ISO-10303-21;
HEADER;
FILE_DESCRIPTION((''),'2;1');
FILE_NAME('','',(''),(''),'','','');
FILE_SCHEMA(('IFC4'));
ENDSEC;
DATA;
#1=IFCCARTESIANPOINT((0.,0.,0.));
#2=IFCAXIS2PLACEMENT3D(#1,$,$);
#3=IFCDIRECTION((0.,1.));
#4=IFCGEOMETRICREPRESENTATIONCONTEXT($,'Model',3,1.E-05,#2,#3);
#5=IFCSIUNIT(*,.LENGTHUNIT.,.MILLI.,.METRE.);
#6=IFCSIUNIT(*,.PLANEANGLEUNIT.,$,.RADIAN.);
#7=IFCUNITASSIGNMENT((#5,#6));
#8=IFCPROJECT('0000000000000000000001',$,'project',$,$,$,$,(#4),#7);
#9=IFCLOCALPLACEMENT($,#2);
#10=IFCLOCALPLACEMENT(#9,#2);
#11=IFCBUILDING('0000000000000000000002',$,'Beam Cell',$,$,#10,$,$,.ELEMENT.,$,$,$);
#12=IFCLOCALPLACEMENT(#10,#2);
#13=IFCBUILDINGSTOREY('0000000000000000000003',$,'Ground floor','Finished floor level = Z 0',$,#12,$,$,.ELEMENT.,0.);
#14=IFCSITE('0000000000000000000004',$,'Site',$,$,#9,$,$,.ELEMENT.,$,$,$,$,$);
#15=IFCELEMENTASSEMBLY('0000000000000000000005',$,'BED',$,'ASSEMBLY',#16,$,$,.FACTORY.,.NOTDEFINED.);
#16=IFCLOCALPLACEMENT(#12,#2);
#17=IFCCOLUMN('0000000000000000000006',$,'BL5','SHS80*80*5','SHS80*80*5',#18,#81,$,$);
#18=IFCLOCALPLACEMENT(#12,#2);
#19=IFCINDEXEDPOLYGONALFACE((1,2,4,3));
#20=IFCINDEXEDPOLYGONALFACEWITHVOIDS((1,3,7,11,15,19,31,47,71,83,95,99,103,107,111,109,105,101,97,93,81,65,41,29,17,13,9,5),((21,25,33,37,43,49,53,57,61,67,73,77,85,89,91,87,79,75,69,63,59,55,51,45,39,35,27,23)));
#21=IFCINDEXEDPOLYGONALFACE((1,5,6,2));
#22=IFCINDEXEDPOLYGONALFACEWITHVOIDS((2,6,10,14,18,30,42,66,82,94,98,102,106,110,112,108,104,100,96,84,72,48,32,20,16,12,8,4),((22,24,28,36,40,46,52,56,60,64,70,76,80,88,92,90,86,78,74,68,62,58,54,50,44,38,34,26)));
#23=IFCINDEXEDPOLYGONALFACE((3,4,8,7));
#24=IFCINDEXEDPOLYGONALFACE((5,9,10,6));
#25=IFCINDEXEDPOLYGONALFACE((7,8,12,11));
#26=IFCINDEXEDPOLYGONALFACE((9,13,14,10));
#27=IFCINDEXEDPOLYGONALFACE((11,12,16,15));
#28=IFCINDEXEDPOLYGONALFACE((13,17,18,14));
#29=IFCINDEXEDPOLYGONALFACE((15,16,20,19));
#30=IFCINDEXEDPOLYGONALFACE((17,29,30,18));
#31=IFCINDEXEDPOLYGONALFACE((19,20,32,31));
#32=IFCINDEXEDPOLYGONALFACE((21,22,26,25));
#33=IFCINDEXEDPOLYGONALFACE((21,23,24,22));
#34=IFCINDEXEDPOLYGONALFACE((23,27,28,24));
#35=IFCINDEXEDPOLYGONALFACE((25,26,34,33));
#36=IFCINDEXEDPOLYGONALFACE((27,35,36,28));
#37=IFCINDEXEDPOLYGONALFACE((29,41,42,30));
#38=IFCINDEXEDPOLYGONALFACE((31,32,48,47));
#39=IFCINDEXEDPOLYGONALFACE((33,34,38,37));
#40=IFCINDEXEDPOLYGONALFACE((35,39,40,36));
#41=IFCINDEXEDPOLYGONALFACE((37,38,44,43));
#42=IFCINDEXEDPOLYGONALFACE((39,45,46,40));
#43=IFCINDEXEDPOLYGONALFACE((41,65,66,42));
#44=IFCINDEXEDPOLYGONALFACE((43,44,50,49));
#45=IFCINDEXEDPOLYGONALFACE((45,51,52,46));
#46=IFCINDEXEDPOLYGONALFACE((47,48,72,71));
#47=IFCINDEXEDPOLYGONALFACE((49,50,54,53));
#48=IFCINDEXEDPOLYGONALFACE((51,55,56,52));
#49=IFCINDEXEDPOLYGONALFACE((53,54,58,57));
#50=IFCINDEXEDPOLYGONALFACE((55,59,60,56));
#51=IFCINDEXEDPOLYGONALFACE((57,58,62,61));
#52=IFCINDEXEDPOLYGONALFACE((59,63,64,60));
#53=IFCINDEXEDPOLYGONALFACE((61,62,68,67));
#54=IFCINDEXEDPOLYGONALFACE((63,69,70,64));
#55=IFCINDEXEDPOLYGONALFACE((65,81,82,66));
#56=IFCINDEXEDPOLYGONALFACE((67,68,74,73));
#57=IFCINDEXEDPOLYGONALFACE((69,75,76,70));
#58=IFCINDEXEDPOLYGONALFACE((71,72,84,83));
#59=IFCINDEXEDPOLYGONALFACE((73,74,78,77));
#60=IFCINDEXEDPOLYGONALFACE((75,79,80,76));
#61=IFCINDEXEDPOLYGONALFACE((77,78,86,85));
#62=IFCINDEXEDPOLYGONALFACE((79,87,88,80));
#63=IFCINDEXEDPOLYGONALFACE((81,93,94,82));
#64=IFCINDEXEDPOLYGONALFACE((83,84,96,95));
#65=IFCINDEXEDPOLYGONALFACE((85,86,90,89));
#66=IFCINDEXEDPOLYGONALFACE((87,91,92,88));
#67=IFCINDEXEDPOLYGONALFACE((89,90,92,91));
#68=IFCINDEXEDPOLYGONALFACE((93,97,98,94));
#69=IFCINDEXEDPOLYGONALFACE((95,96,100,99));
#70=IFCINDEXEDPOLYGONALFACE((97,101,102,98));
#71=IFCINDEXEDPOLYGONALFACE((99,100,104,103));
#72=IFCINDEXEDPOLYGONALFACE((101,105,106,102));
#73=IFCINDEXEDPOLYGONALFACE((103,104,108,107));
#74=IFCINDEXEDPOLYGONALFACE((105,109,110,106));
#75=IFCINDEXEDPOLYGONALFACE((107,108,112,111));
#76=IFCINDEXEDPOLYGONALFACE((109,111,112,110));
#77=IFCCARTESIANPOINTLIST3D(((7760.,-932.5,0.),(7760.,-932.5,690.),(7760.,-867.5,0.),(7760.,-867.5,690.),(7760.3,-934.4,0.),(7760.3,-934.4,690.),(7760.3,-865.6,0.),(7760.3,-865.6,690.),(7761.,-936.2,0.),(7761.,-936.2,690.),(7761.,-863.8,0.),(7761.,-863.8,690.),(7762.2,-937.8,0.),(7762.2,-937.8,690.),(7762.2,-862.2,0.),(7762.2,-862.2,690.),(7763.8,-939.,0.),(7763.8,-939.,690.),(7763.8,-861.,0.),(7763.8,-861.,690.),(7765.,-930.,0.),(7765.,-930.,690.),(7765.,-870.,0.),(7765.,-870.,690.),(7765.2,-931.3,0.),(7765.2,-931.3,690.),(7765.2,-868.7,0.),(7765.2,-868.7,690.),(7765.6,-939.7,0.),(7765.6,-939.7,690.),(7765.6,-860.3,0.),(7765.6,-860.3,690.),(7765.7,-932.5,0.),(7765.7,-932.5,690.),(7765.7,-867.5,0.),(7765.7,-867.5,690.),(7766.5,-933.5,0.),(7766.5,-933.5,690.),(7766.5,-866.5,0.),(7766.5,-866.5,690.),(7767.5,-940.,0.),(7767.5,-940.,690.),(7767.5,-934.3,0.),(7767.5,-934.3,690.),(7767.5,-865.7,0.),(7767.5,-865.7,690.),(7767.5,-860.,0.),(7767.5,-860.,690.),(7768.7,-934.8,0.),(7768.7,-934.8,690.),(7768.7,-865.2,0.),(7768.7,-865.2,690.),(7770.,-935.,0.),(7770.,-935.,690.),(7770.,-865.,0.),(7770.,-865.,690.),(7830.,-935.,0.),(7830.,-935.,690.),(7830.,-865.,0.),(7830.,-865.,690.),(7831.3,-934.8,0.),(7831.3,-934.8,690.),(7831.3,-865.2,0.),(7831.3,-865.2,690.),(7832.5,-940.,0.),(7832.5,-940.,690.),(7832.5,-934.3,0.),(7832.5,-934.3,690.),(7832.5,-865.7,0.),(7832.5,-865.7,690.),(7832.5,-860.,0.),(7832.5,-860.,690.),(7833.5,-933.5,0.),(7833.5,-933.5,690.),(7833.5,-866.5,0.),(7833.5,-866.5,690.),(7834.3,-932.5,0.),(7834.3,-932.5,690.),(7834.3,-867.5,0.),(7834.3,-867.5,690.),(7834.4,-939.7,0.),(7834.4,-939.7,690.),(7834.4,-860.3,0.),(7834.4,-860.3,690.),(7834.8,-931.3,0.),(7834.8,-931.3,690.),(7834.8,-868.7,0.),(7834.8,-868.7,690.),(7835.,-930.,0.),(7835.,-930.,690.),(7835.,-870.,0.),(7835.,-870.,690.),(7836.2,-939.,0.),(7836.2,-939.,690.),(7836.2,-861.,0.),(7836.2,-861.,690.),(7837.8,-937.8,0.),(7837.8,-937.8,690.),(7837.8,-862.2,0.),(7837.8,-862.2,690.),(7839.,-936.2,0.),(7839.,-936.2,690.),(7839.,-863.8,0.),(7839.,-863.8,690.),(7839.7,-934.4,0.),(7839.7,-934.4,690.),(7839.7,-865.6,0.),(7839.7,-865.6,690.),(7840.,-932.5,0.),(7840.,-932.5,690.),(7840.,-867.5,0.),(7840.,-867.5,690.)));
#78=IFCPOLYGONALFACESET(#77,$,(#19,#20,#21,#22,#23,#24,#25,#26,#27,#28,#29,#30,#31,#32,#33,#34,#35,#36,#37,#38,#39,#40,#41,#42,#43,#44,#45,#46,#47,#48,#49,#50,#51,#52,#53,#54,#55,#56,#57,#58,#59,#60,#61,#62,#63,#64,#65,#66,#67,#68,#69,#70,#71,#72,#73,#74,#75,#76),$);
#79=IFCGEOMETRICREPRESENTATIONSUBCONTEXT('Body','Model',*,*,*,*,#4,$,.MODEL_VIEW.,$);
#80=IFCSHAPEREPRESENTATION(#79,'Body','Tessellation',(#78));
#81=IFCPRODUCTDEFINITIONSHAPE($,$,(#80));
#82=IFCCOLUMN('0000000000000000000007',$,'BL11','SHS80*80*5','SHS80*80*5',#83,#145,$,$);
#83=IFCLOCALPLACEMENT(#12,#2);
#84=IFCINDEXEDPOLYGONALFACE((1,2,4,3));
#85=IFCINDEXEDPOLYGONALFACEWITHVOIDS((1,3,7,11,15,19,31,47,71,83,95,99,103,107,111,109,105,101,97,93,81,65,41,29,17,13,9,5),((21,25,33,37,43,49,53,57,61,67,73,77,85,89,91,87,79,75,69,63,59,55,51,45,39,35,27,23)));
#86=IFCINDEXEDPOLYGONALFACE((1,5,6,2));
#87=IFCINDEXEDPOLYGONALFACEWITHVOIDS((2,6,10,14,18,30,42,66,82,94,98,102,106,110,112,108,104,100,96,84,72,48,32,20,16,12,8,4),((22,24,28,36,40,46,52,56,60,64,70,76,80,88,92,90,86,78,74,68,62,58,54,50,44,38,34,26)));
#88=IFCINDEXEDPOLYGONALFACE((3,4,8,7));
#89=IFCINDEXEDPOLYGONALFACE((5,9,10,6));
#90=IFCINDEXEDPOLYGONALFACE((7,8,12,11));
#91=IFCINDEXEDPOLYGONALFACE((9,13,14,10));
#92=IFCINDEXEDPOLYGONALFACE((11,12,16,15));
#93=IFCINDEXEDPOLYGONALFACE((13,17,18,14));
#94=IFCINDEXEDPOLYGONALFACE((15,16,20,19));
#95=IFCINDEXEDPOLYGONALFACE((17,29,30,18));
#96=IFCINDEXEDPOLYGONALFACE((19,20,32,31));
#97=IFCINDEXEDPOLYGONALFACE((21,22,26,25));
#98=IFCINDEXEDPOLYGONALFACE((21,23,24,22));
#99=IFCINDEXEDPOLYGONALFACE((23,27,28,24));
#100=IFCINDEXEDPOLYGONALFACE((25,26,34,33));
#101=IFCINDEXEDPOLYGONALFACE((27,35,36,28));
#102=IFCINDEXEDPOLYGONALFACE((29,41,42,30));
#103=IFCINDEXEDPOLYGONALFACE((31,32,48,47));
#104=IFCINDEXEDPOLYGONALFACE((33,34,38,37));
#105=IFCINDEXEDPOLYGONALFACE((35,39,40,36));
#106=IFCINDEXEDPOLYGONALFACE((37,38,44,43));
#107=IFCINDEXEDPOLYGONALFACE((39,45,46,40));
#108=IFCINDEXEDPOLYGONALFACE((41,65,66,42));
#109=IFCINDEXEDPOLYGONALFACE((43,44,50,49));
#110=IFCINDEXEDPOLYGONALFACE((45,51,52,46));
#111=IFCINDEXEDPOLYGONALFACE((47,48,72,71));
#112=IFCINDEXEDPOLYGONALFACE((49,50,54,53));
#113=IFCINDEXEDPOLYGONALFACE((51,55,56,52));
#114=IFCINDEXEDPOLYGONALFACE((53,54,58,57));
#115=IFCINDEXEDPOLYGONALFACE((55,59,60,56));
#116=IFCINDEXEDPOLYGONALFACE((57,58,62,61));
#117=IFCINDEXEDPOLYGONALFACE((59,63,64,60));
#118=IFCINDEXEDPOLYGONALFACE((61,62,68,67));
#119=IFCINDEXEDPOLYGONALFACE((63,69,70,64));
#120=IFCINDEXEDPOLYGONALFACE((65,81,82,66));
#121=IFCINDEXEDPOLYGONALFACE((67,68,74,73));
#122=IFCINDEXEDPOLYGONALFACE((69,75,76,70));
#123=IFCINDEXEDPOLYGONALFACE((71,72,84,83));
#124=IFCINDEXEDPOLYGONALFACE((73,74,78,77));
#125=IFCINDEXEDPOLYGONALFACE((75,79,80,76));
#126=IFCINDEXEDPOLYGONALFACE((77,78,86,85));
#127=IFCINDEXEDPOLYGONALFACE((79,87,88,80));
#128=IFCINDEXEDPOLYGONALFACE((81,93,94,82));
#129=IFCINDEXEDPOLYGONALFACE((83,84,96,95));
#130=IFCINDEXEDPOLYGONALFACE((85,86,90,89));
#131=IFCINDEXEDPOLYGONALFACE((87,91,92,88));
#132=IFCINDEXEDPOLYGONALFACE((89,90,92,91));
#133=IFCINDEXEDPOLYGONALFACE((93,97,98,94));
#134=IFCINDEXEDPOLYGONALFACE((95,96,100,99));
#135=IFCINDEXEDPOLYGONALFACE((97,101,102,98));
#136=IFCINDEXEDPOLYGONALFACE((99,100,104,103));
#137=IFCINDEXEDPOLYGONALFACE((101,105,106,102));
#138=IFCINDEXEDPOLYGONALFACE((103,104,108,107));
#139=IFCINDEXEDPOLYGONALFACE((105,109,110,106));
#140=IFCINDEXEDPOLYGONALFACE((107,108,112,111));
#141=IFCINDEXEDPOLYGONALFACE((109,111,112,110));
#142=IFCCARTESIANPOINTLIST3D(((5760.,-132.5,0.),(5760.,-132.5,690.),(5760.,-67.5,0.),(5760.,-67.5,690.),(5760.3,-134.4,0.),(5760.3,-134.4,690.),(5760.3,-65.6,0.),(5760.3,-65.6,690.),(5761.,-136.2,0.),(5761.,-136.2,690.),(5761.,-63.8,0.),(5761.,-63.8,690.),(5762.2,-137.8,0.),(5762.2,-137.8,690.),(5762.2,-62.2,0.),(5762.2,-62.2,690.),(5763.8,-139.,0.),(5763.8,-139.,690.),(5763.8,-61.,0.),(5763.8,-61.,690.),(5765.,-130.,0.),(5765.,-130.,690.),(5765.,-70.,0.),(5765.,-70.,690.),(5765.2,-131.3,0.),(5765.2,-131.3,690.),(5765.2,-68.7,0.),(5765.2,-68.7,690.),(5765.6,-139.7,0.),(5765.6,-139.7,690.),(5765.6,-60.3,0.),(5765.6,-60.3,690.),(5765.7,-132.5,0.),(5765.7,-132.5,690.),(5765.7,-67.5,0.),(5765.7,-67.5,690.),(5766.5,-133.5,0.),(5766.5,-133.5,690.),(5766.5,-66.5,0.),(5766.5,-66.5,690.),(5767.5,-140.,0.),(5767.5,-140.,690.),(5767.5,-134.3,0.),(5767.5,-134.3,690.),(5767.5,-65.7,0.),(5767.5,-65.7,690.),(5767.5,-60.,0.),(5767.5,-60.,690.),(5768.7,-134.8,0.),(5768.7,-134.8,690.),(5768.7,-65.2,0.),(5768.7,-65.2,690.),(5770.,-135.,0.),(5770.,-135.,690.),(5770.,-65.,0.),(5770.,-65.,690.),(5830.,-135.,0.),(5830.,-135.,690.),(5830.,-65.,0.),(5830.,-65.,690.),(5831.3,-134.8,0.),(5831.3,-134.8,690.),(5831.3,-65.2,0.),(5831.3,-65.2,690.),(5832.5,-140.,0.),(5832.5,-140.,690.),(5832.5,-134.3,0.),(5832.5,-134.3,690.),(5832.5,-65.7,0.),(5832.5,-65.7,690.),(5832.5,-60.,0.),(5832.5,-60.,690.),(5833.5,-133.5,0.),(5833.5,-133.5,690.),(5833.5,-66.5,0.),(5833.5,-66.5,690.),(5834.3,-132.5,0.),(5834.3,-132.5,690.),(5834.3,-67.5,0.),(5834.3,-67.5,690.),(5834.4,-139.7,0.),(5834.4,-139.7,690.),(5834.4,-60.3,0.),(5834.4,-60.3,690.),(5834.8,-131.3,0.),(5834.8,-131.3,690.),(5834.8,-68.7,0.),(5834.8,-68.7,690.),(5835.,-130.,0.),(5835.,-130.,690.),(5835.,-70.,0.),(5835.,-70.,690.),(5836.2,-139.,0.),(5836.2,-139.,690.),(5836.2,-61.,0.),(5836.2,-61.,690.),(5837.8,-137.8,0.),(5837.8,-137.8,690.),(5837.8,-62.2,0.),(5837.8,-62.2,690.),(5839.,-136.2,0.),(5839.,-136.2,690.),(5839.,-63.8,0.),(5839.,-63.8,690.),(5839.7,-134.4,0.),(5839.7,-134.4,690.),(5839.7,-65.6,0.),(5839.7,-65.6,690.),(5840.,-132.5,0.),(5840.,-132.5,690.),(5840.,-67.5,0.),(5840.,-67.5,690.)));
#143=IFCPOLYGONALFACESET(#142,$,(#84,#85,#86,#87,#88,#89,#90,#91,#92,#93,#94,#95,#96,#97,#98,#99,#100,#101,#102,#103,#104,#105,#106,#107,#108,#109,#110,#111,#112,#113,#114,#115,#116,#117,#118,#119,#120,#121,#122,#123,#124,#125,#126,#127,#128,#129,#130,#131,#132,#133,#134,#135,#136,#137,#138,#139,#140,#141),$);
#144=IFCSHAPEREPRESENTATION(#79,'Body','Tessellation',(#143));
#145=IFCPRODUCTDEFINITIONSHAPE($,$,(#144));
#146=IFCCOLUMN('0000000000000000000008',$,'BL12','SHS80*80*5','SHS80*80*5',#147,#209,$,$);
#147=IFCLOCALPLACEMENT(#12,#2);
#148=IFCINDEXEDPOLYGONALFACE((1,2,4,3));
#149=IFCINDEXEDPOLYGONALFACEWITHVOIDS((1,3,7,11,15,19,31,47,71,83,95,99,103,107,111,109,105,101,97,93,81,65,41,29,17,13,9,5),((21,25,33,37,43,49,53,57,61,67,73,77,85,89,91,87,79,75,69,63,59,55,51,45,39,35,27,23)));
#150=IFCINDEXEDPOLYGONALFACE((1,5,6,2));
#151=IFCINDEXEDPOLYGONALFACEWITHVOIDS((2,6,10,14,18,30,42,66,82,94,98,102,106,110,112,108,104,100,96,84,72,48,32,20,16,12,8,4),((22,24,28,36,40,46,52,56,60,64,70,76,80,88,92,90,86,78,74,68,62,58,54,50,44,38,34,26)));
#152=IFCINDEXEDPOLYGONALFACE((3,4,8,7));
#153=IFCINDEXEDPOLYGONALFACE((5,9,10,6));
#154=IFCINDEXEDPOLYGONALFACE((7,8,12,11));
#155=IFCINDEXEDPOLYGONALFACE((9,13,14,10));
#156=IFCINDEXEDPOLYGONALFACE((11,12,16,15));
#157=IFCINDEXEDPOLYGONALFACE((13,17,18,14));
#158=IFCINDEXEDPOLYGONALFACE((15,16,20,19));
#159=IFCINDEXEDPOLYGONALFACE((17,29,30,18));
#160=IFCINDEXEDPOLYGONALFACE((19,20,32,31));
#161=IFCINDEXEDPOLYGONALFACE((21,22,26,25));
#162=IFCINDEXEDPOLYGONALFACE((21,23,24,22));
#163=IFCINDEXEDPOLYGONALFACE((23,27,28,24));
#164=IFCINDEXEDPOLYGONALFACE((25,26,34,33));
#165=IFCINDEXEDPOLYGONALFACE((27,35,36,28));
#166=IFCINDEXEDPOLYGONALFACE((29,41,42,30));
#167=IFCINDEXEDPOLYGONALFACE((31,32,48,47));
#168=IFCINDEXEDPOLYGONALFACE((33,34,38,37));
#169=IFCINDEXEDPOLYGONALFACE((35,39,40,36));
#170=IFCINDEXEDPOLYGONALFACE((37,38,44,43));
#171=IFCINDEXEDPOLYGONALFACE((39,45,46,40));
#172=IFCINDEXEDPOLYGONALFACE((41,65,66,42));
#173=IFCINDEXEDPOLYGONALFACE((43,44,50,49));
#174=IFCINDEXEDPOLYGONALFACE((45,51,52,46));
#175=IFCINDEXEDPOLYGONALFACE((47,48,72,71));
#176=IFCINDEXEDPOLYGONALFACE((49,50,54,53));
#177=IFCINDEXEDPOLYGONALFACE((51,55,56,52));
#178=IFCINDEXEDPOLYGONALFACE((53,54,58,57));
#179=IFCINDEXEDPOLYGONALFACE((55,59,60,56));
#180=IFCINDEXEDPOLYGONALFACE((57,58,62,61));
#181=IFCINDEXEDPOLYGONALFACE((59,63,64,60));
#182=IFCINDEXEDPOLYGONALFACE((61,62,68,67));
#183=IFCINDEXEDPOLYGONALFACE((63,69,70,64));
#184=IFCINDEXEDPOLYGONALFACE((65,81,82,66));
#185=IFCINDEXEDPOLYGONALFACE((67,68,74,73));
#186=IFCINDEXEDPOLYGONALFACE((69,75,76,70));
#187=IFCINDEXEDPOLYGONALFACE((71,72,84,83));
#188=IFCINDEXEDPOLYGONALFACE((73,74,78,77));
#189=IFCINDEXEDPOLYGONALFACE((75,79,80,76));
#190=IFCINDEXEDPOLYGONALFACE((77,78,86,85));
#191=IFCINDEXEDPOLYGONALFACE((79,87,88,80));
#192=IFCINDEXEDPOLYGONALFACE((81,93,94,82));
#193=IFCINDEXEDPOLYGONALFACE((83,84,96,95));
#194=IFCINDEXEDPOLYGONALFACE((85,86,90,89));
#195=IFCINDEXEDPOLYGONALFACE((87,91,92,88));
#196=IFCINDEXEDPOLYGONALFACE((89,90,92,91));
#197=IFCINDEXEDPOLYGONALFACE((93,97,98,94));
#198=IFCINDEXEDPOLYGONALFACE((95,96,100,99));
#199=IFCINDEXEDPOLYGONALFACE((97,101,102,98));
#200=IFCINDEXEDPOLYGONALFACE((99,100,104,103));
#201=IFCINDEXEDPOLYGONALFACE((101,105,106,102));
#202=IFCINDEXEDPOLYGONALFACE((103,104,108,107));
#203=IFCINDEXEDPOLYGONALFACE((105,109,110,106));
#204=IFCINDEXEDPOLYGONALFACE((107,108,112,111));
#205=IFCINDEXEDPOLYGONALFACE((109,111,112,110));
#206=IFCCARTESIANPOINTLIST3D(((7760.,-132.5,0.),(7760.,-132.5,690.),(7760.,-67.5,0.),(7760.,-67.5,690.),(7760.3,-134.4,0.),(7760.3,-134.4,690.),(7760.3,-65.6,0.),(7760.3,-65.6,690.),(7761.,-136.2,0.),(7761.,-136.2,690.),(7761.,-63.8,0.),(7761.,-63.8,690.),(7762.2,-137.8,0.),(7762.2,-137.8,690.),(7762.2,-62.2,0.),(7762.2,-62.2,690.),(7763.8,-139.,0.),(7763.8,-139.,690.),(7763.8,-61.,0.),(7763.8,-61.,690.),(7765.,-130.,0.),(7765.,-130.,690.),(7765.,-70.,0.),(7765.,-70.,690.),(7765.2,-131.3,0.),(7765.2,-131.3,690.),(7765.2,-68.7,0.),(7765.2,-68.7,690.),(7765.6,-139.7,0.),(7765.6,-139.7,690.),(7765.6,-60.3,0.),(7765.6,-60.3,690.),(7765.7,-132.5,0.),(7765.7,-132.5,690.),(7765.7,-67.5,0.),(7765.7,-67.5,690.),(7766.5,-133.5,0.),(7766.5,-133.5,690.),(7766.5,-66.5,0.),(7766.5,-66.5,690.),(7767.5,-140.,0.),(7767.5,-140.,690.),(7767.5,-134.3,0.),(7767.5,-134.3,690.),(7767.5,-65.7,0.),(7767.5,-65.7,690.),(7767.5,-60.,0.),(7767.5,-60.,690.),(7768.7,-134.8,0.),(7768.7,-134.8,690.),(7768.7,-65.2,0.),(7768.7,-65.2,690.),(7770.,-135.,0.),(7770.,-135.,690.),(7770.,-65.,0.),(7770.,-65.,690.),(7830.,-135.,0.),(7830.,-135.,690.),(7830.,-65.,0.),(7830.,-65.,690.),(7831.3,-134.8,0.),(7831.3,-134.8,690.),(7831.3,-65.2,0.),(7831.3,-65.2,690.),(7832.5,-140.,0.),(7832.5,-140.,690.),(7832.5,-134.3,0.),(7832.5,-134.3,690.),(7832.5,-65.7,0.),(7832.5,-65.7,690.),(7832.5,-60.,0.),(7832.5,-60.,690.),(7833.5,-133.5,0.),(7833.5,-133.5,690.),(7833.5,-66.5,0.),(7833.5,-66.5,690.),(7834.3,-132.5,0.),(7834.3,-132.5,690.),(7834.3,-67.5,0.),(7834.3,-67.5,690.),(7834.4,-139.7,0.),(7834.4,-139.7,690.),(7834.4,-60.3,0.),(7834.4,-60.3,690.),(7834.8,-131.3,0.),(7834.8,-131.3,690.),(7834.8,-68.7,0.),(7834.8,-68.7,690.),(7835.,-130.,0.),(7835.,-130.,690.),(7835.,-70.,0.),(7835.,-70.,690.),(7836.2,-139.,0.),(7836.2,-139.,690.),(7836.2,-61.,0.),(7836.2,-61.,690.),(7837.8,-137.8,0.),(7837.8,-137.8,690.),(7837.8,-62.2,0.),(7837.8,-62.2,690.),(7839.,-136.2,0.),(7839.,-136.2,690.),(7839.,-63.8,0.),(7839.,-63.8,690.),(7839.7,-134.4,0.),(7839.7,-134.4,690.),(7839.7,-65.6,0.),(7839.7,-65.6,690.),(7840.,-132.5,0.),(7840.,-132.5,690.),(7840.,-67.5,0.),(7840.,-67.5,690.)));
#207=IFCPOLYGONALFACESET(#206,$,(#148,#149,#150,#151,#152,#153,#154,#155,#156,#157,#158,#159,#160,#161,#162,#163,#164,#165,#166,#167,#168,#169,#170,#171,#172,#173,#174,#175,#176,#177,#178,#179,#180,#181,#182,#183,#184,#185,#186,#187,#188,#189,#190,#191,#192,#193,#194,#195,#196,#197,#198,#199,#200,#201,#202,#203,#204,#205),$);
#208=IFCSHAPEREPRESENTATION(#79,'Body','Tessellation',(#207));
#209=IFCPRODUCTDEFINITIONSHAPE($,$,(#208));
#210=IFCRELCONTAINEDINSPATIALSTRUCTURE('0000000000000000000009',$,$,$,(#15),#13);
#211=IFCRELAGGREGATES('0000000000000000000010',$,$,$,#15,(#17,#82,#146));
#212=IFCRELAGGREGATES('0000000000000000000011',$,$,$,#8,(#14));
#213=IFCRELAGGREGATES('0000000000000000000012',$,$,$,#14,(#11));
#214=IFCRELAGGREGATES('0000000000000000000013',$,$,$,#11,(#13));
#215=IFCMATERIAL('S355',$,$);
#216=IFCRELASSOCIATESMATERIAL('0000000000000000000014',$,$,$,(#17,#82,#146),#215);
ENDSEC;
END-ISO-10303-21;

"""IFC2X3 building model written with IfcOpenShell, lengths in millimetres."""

from ifc_helpers import new_model, si_unit, direction, frame, origin, origin_2d, place, context, subcontext, project, spatial, hollow_rectangle, extrude, material, element, aggregate, save


model = new_model("IFC2X3")

# Units and contexts
model_context = context("Model", 3, precision=1e-05, world=origin(), true_north=direction((0.0, 1.0)))
body_context = subcontext(model_context, "Body", "Model", "MODEL_VIEW")
ifc_project = project(units=[si_unit("LENGTHUNIT", "METRE", prefix="MILLI"), si_unit("PLANEANGLEUNIT", "RADIAN")], contexts=[model_context])

# Site, building, storey
site_placement = place(None, origin())
site = spatial("IfcSite", under=ifc_project, at=site_placement, Name="Site", CompositionType="ELEMENT")
building_placement = place(site_placement, origin())
building = spatial("IfcBuilding", under=site, at=building_placement, Name="Beam Cell", CompositionType="ELEMENT")
storey_placement = place(building_placement, origin())
storey = spatial("IfcBuildingStorey", under=building, at=storey_placement, Name="Ground floor", Description="Finished floor level = Z 0", CompositionType="ELEMENT", Elevation=0.0)

# Shared definitions
ifc_material = material(Name="S355")

# Element assembly, columns
assembly_1_placement = place(storey_placement, origin())
assembly_1 = element("IfcElementAssembly", 1, at=assembly_1_placement, inside=storey, Name="BED", ObjectType="ASSEMBLY", AssemblyPlace="FACTORY", PredefinedType="NOTDEFINED")
column_1_placement = place(storey_placement, frame((7800.0, -900.0, 0.0), z_axis=(0.0, 0.0, 1.0), x_axis=(1.0, 0.0, 0.0)))
column_1 = element("IfcColumn", 2, at=column_1_placement, material=ifc_material, Name="BL5", Description="SHS80*80*5", ObjectType="SHS80*80*5", context=body_context, shape_type="SweptSolid", body=[
    extrude(hollow_rectangle(XDim=80.0, YDim=80.0, WallThickness=5.0, InnerFilletRadius=5.0, OuterFilletRadius=7.5, at=origin_2d()), origin(), (0.0, 0.0, 1.0), 690.0),
])
column_2_placement = place(storey_placement, frame((5800.0, -100.0, 0.0), z_axis=(0.0, 0.0, 1.0), x_axis=(1.0, 0.0, 0.0)))
column_2 = element("IfcColumn", 3, at=column_2_placement, material=ifc_material, Name="BL11", Description="SHS80*80*5", ObjectType="SHS80*80*5", context=body_context, shape_type="SweptSolid", body=[
    extrude(hollow_rectangle(XDim=80.0, YDim=80.0, WallThickness=5.0, InnerFilletRadius=5.0, OuterFilletRadius=7.5, at=origin_2d()), origin(), (0.0, 0.0, 1.0), 690.0),
])
column_3_placement = place(storey_placement, frame((7800.0, -100.0, 0.0), z_axis=(0.0, 0.0, 1.0), x_axis=(1.0, 0.0, 0.0)))
column_3 = element("IfcColumn", 4, at=column_3_placement, material=ifc_material, Name="BL12", Description="SHS80*80*5", ObjectType="SHS80*80*5", context=body_context, shape_type="SweptSolid", body=[
    extrude(hollow_rectangle(XDim=80.0, YDim=80.0, WallThickness=5.0, InnerFilletRadius=5.0, OuterFilletRadius=7.5, at=origin_2d()), origin(), (0.0, 0.0, 1.0), 690.0),
])

aggregate(assembly_1, [column_1, column_2, column_3])

save(model, "model.ifc")
